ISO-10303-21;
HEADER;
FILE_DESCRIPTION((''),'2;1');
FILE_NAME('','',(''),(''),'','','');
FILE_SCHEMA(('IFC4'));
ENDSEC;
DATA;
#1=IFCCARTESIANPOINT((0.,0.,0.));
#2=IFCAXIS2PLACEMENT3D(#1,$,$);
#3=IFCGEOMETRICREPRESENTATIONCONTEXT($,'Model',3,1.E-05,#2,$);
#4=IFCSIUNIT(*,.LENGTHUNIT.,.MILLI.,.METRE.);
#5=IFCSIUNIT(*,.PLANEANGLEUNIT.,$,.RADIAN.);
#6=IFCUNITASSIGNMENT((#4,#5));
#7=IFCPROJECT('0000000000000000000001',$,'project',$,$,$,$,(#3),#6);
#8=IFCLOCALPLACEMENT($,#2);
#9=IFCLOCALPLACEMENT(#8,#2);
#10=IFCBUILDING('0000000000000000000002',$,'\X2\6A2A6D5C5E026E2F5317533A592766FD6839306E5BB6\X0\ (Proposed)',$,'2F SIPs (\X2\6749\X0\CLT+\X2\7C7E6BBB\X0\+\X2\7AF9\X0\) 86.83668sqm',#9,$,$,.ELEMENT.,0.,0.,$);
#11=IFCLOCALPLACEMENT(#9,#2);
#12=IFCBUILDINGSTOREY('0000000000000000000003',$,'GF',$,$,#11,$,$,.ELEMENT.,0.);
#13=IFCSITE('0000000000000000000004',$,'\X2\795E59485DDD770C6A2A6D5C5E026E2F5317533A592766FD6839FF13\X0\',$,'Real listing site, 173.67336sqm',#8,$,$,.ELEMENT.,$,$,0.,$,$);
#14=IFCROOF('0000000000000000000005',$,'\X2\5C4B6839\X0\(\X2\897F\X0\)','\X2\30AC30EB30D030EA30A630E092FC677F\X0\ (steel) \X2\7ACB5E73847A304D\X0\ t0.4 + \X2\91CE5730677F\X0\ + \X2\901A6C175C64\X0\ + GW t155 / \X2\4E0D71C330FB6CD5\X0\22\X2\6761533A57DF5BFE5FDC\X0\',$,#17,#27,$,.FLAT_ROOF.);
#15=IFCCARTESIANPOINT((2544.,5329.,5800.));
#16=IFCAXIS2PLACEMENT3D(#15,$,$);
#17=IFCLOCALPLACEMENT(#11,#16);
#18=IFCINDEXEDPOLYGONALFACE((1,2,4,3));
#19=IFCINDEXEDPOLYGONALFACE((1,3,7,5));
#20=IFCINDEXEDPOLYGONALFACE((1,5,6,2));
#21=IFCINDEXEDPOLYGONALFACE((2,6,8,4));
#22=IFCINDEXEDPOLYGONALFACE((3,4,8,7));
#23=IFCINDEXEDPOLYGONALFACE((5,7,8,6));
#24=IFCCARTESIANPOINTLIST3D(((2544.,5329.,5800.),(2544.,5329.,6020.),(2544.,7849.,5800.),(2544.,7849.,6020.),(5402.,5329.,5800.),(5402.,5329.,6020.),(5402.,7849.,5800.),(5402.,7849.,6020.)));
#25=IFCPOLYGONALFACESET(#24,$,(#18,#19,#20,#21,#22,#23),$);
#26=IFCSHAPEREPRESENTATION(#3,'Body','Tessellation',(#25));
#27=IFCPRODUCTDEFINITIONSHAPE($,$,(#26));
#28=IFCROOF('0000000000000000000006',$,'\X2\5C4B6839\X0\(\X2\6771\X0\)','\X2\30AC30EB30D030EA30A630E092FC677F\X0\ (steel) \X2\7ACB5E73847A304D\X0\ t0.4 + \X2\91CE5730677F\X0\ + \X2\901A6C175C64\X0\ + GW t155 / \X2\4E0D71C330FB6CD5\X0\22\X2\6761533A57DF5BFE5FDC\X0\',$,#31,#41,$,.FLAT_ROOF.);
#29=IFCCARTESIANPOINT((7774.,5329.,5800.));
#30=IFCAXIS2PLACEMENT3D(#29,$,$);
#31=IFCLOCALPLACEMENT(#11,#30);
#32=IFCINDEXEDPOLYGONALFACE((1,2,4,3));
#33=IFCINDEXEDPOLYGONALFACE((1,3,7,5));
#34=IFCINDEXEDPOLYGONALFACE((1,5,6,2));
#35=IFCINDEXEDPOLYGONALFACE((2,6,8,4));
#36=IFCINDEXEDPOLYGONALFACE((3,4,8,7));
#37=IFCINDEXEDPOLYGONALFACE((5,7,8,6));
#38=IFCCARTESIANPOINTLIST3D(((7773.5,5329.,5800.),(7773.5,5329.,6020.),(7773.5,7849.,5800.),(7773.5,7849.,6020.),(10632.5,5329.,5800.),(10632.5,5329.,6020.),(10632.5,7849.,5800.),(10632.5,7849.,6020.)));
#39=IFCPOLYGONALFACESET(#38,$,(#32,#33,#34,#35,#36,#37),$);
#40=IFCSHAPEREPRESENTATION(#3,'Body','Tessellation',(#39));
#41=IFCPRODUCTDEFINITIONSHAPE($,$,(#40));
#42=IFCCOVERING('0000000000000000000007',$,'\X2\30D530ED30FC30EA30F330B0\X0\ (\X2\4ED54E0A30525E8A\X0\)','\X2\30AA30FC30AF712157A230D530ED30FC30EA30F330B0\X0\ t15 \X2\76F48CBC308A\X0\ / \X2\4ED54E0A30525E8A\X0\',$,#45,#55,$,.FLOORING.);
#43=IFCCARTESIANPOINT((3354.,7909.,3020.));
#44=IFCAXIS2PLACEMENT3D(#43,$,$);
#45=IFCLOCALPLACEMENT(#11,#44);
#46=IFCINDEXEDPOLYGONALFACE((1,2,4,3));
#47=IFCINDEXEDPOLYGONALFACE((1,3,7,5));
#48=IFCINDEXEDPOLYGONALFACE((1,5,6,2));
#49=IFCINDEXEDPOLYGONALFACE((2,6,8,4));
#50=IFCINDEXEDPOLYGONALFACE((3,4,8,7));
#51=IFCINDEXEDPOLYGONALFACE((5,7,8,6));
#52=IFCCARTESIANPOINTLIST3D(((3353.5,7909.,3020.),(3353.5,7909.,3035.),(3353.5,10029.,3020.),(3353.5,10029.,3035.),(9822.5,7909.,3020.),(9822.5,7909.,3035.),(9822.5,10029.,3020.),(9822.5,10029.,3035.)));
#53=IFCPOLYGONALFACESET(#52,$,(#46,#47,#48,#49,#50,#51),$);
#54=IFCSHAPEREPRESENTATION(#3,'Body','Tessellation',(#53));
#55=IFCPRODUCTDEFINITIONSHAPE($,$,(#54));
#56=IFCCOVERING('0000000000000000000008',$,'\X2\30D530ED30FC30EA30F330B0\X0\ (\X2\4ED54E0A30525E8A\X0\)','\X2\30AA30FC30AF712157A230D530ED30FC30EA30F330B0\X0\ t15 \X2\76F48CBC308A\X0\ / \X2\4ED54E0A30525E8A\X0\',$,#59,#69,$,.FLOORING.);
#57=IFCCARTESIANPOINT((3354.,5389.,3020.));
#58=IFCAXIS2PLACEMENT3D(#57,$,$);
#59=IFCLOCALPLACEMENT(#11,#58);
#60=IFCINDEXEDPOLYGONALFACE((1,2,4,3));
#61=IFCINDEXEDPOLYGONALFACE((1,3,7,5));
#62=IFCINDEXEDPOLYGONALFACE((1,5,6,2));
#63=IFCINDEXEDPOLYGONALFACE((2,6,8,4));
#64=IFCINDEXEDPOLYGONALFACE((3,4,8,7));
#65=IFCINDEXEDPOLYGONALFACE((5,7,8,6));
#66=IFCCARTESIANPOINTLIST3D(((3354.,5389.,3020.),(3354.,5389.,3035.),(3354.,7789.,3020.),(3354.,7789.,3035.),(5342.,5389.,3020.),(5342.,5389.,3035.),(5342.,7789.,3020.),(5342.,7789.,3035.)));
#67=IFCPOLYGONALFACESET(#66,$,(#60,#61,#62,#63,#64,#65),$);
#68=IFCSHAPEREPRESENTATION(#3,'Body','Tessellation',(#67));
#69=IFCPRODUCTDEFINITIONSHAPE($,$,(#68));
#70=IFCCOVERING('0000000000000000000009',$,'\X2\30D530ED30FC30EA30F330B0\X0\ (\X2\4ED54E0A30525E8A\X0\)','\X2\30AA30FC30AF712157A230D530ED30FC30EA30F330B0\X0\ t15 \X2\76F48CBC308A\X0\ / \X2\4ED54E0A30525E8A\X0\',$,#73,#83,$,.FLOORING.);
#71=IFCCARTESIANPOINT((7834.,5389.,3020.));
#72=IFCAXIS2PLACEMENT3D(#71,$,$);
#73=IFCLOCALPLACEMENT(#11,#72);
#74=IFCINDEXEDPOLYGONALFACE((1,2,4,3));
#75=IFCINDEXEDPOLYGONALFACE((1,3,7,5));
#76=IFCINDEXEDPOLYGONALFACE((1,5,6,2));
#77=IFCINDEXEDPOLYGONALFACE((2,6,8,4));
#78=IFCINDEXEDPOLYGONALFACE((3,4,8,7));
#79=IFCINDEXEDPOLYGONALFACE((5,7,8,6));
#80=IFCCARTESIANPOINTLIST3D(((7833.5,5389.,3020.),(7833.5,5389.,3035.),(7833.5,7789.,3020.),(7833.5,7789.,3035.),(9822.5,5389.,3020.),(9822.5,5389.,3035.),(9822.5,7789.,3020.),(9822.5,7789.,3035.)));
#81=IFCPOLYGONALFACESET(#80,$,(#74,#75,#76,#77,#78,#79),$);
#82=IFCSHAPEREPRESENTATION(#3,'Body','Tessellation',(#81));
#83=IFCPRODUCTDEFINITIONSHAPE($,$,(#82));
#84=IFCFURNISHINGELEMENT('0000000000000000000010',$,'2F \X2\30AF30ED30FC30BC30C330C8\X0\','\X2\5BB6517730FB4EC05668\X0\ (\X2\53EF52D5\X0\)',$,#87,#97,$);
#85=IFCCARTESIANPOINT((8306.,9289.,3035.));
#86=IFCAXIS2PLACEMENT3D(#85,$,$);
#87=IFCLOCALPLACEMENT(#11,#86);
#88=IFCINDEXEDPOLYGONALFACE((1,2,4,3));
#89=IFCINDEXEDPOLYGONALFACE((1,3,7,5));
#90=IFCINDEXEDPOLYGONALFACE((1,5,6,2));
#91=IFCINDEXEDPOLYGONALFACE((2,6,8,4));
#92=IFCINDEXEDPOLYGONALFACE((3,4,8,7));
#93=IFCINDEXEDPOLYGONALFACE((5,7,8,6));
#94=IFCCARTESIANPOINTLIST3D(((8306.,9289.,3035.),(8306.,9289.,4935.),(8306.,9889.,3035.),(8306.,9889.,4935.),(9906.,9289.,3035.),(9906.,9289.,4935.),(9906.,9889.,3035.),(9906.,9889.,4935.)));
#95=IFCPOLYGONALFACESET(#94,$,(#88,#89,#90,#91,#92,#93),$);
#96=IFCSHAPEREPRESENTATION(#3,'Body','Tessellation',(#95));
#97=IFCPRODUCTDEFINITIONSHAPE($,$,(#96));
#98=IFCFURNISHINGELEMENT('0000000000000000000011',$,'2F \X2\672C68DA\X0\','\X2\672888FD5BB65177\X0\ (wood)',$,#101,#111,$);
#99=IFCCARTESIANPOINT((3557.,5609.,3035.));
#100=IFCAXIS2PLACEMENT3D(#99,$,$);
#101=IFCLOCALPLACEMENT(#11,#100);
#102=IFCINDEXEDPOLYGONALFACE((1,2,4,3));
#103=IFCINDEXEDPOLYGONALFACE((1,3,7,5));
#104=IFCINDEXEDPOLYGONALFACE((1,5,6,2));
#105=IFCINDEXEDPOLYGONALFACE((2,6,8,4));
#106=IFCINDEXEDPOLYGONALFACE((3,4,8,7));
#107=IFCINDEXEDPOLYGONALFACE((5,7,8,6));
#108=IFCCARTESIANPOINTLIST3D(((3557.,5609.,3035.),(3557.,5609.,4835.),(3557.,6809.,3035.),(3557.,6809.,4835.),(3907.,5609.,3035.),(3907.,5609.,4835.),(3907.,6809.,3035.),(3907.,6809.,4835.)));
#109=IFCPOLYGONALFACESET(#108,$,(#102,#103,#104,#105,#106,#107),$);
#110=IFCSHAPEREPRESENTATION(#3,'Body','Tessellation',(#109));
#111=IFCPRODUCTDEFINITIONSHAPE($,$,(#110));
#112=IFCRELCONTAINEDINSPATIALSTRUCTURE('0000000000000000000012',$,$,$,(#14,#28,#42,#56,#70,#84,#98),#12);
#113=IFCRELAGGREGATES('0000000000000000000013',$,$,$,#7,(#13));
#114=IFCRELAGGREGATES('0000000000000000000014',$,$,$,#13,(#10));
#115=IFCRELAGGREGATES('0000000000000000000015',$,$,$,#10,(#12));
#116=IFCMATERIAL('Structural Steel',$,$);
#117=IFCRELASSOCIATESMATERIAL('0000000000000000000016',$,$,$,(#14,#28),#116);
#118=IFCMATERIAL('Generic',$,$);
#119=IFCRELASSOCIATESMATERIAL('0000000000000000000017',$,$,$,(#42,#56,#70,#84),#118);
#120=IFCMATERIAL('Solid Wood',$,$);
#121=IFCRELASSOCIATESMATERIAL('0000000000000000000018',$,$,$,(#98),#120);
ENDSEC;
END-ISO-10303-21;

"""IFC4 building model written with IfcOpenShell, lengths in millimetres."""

from ifc_helpers import new_model, si_unit, frame, frame_2d, origin, place, context, project, spatial, rectangle, extrude, material, element, save


model = new_model("IFC4")

# Units and contexts
model_context = context("Model", 3, precision=1e-05, world=origin())
ifc_project = project(units=[si_unit("LENGTHUNIT", "METRE", prefix="MILLI"), si_unit("PLANEANGLEUNIT", "RADIAN")], contexts=[model_context])

# Site, building, storey
site_placement = place(None, origin())
site = spatial("IfcSite", under=ifc_project, at=site_placement, Name="神奈川県横浜市港北区大曽根３", ObjectType="Real listing site, 173.67336sqm", CompositionType="ELEMENT", RefElevation=0.0)
building_placement = place(site_placement, origin())
building = spatial("IfcBuilding", under=site, at=building_placement, Name="横浜市港北区大曽根の家 (Proposed)", ObjectType="2F SIPs (杉CLT+籾殻+竹) 86.83668sqm", CompositionType="ELEMENT", ElevationOfRefHeight=0.0, ElevationOfTerrain=0.0)
storey_placement = place(building_placement, origin())
storey = spatial("IfcBuildingStorey", under=building, at=storey_placement, Name="GF", CompositionType="ELEMENT", Elevation=0.0)

# Shared definitions
ifc_material_1 = material(Name="Solid Wood")

# Roofs
ifc_material_2 = material(Name="Structural Steel")
roof_1_placement = place(storey_placement, frame((2544.0, 5329.0, 5800.0)))
element("IfcRoof", 1, at=roof_1_placement, inside=storey, material=ifc_material_2, Name="屋根(西)", Description="ガルバリウム鋼板 (steel) 立平葺き t0.4 + 野地板 + 通気層 + GW t155 / 不燃・法22条区域対応", PredefinedType="FLAT_ROOF", context=model_context, shape_type="SweptSolid", body=[
    extrude(rectangle(XDim=2858.0, YDim=2520.0, at=frame_2d((1429.0, 1260.0))), frame((2544.0, 5329.0, 5800.0)), (0.0, 0.0, 1.0), 220.0),
])
roof_2_placement = place(storey_placement, frame((7774.0, 5329.0, 5800.0)))
element("IfcRoof", 2, at=roof_2_placement, inside=storey, material=ifc_material_2, Name="屋根(東)", Description="ガルバリウム鋼板 (steel) 立平葺き t0.4 + 野地板 + 通気層 + GW t155 / 不燃・法22条区域対応", PredefinedType="FLAT_ROOF", context=model_context, shape_type="SweptSolid", body=[
    extrude(rectangle(XDim=2859.0, YDim=2520.0, at=frame_2d((1429.0, 1260.0))), frame((7774.0, 5329.0, 5800.0)), (0.0, 0.0, 1.0), 220.0),
])

# Coverings
ifc_material_3 = material(Name="Generic")
covering_1_placement = place(storey_placement, frame((3354.0, 7909.0, 3020.0)))
element("IfcCovering", 3, at=covering_1_placement, inside=storey, material=ifc_material_3, Name="フローリング (仕上げ床)", Description="オーク無垢フローリング t15 直貼り / 仕上げ床", PredefinedType="FLOORING", context=model_context, shape_type="SweptSolid", body=[
    extrude(rectangle(XDim=6469.0, YDim=2120.0, at=frame_2d((3234.0, 1060.0))), frame((3354.0, 7909.0, 3020.0)), (0.0, 0.0, 1.0), 15.0),
])
covering_2_placement = place(storey_placement, frame((3354.0, 5389.0, 3020.0)))
element("IfcCovering", 4, at=covering_2_placement, inside=storey, material=ifc_material_3, Name="フローリング (仕上げ床)", Description="オーク無垢フローリング t15 直貼り / 仕上げ床", PredefinedType="FLOORING", context=model_context, shape_type="SweptSolid", body=[
    extrude(rectangle(XDim=1988.0, YDim=2400.0, at=frame_2d((994.0, 1200.0))), frame((3354.0, 5389.0, 3020.0)), (0.0, 0.0, 1.0), 15.0),
])
covering_3_placement = place(storey_placement, frame((7834.0, 5389.0, 3020.0)))
element("IfcCovering", 5, at=covering_3_placement, inside=storey, material=ifc_material_3, Name="フローリング (仕上げ床)", Description="オーク無垢フローリング t15 直貼り / 仕上げ床", PredefinedType="FLOORING", context=model_context, shape_type="SweptSolid", body=[
    extrude(rectangle(XDim=1989.0, YDim=2400.0, at=frame_2d((994.0, 1200.0))), frame((7834.0, 5389.0, 3020.0)), (0.0, 0.0, 1.0), 15.0),
])

# Furnishing elements
furnishing_1_placement = place(storey_placement, frame((8306.0, 9289.0, 3035.0)))
element("IfcFurnishingElement", 6, at=furnishing_1_placement, inside=storey, material=ifc_material_3, Name="2F クローゼット", Description="家具・什器 (可動)", context=model_context, shape_type="SweptSolid", body=[
    extrude(rectangle(XDim=1600.0, YDim=600.0, at=frame_2d((800.0, 300.0))), frame((8306.0, 9289.0, 3035.0)), (0.0, 0.0, 1.0), 1900.0),
])
furnishing_2_placement = place(storey_placement, frame((3557.0, 5609.0, 3035.0)))
element("IfcFurnishingElement", 7, at=furnishing_2_placement, inside=storey, material=ifc_material_1, Name="2F 本棚", Description="木製家具 (wood)", context=model_context, shape_type="SweptSolid", body=[
    extrude(rectangle(XDim=350.0, YDim=1200.0, at=frame_2d((175.0, 600.0))), frame((3557.0, 5609.0, 3035.0)), (0.0, 0.0, 1.0), 1800.0),
])

save(model, "model.ifc")
